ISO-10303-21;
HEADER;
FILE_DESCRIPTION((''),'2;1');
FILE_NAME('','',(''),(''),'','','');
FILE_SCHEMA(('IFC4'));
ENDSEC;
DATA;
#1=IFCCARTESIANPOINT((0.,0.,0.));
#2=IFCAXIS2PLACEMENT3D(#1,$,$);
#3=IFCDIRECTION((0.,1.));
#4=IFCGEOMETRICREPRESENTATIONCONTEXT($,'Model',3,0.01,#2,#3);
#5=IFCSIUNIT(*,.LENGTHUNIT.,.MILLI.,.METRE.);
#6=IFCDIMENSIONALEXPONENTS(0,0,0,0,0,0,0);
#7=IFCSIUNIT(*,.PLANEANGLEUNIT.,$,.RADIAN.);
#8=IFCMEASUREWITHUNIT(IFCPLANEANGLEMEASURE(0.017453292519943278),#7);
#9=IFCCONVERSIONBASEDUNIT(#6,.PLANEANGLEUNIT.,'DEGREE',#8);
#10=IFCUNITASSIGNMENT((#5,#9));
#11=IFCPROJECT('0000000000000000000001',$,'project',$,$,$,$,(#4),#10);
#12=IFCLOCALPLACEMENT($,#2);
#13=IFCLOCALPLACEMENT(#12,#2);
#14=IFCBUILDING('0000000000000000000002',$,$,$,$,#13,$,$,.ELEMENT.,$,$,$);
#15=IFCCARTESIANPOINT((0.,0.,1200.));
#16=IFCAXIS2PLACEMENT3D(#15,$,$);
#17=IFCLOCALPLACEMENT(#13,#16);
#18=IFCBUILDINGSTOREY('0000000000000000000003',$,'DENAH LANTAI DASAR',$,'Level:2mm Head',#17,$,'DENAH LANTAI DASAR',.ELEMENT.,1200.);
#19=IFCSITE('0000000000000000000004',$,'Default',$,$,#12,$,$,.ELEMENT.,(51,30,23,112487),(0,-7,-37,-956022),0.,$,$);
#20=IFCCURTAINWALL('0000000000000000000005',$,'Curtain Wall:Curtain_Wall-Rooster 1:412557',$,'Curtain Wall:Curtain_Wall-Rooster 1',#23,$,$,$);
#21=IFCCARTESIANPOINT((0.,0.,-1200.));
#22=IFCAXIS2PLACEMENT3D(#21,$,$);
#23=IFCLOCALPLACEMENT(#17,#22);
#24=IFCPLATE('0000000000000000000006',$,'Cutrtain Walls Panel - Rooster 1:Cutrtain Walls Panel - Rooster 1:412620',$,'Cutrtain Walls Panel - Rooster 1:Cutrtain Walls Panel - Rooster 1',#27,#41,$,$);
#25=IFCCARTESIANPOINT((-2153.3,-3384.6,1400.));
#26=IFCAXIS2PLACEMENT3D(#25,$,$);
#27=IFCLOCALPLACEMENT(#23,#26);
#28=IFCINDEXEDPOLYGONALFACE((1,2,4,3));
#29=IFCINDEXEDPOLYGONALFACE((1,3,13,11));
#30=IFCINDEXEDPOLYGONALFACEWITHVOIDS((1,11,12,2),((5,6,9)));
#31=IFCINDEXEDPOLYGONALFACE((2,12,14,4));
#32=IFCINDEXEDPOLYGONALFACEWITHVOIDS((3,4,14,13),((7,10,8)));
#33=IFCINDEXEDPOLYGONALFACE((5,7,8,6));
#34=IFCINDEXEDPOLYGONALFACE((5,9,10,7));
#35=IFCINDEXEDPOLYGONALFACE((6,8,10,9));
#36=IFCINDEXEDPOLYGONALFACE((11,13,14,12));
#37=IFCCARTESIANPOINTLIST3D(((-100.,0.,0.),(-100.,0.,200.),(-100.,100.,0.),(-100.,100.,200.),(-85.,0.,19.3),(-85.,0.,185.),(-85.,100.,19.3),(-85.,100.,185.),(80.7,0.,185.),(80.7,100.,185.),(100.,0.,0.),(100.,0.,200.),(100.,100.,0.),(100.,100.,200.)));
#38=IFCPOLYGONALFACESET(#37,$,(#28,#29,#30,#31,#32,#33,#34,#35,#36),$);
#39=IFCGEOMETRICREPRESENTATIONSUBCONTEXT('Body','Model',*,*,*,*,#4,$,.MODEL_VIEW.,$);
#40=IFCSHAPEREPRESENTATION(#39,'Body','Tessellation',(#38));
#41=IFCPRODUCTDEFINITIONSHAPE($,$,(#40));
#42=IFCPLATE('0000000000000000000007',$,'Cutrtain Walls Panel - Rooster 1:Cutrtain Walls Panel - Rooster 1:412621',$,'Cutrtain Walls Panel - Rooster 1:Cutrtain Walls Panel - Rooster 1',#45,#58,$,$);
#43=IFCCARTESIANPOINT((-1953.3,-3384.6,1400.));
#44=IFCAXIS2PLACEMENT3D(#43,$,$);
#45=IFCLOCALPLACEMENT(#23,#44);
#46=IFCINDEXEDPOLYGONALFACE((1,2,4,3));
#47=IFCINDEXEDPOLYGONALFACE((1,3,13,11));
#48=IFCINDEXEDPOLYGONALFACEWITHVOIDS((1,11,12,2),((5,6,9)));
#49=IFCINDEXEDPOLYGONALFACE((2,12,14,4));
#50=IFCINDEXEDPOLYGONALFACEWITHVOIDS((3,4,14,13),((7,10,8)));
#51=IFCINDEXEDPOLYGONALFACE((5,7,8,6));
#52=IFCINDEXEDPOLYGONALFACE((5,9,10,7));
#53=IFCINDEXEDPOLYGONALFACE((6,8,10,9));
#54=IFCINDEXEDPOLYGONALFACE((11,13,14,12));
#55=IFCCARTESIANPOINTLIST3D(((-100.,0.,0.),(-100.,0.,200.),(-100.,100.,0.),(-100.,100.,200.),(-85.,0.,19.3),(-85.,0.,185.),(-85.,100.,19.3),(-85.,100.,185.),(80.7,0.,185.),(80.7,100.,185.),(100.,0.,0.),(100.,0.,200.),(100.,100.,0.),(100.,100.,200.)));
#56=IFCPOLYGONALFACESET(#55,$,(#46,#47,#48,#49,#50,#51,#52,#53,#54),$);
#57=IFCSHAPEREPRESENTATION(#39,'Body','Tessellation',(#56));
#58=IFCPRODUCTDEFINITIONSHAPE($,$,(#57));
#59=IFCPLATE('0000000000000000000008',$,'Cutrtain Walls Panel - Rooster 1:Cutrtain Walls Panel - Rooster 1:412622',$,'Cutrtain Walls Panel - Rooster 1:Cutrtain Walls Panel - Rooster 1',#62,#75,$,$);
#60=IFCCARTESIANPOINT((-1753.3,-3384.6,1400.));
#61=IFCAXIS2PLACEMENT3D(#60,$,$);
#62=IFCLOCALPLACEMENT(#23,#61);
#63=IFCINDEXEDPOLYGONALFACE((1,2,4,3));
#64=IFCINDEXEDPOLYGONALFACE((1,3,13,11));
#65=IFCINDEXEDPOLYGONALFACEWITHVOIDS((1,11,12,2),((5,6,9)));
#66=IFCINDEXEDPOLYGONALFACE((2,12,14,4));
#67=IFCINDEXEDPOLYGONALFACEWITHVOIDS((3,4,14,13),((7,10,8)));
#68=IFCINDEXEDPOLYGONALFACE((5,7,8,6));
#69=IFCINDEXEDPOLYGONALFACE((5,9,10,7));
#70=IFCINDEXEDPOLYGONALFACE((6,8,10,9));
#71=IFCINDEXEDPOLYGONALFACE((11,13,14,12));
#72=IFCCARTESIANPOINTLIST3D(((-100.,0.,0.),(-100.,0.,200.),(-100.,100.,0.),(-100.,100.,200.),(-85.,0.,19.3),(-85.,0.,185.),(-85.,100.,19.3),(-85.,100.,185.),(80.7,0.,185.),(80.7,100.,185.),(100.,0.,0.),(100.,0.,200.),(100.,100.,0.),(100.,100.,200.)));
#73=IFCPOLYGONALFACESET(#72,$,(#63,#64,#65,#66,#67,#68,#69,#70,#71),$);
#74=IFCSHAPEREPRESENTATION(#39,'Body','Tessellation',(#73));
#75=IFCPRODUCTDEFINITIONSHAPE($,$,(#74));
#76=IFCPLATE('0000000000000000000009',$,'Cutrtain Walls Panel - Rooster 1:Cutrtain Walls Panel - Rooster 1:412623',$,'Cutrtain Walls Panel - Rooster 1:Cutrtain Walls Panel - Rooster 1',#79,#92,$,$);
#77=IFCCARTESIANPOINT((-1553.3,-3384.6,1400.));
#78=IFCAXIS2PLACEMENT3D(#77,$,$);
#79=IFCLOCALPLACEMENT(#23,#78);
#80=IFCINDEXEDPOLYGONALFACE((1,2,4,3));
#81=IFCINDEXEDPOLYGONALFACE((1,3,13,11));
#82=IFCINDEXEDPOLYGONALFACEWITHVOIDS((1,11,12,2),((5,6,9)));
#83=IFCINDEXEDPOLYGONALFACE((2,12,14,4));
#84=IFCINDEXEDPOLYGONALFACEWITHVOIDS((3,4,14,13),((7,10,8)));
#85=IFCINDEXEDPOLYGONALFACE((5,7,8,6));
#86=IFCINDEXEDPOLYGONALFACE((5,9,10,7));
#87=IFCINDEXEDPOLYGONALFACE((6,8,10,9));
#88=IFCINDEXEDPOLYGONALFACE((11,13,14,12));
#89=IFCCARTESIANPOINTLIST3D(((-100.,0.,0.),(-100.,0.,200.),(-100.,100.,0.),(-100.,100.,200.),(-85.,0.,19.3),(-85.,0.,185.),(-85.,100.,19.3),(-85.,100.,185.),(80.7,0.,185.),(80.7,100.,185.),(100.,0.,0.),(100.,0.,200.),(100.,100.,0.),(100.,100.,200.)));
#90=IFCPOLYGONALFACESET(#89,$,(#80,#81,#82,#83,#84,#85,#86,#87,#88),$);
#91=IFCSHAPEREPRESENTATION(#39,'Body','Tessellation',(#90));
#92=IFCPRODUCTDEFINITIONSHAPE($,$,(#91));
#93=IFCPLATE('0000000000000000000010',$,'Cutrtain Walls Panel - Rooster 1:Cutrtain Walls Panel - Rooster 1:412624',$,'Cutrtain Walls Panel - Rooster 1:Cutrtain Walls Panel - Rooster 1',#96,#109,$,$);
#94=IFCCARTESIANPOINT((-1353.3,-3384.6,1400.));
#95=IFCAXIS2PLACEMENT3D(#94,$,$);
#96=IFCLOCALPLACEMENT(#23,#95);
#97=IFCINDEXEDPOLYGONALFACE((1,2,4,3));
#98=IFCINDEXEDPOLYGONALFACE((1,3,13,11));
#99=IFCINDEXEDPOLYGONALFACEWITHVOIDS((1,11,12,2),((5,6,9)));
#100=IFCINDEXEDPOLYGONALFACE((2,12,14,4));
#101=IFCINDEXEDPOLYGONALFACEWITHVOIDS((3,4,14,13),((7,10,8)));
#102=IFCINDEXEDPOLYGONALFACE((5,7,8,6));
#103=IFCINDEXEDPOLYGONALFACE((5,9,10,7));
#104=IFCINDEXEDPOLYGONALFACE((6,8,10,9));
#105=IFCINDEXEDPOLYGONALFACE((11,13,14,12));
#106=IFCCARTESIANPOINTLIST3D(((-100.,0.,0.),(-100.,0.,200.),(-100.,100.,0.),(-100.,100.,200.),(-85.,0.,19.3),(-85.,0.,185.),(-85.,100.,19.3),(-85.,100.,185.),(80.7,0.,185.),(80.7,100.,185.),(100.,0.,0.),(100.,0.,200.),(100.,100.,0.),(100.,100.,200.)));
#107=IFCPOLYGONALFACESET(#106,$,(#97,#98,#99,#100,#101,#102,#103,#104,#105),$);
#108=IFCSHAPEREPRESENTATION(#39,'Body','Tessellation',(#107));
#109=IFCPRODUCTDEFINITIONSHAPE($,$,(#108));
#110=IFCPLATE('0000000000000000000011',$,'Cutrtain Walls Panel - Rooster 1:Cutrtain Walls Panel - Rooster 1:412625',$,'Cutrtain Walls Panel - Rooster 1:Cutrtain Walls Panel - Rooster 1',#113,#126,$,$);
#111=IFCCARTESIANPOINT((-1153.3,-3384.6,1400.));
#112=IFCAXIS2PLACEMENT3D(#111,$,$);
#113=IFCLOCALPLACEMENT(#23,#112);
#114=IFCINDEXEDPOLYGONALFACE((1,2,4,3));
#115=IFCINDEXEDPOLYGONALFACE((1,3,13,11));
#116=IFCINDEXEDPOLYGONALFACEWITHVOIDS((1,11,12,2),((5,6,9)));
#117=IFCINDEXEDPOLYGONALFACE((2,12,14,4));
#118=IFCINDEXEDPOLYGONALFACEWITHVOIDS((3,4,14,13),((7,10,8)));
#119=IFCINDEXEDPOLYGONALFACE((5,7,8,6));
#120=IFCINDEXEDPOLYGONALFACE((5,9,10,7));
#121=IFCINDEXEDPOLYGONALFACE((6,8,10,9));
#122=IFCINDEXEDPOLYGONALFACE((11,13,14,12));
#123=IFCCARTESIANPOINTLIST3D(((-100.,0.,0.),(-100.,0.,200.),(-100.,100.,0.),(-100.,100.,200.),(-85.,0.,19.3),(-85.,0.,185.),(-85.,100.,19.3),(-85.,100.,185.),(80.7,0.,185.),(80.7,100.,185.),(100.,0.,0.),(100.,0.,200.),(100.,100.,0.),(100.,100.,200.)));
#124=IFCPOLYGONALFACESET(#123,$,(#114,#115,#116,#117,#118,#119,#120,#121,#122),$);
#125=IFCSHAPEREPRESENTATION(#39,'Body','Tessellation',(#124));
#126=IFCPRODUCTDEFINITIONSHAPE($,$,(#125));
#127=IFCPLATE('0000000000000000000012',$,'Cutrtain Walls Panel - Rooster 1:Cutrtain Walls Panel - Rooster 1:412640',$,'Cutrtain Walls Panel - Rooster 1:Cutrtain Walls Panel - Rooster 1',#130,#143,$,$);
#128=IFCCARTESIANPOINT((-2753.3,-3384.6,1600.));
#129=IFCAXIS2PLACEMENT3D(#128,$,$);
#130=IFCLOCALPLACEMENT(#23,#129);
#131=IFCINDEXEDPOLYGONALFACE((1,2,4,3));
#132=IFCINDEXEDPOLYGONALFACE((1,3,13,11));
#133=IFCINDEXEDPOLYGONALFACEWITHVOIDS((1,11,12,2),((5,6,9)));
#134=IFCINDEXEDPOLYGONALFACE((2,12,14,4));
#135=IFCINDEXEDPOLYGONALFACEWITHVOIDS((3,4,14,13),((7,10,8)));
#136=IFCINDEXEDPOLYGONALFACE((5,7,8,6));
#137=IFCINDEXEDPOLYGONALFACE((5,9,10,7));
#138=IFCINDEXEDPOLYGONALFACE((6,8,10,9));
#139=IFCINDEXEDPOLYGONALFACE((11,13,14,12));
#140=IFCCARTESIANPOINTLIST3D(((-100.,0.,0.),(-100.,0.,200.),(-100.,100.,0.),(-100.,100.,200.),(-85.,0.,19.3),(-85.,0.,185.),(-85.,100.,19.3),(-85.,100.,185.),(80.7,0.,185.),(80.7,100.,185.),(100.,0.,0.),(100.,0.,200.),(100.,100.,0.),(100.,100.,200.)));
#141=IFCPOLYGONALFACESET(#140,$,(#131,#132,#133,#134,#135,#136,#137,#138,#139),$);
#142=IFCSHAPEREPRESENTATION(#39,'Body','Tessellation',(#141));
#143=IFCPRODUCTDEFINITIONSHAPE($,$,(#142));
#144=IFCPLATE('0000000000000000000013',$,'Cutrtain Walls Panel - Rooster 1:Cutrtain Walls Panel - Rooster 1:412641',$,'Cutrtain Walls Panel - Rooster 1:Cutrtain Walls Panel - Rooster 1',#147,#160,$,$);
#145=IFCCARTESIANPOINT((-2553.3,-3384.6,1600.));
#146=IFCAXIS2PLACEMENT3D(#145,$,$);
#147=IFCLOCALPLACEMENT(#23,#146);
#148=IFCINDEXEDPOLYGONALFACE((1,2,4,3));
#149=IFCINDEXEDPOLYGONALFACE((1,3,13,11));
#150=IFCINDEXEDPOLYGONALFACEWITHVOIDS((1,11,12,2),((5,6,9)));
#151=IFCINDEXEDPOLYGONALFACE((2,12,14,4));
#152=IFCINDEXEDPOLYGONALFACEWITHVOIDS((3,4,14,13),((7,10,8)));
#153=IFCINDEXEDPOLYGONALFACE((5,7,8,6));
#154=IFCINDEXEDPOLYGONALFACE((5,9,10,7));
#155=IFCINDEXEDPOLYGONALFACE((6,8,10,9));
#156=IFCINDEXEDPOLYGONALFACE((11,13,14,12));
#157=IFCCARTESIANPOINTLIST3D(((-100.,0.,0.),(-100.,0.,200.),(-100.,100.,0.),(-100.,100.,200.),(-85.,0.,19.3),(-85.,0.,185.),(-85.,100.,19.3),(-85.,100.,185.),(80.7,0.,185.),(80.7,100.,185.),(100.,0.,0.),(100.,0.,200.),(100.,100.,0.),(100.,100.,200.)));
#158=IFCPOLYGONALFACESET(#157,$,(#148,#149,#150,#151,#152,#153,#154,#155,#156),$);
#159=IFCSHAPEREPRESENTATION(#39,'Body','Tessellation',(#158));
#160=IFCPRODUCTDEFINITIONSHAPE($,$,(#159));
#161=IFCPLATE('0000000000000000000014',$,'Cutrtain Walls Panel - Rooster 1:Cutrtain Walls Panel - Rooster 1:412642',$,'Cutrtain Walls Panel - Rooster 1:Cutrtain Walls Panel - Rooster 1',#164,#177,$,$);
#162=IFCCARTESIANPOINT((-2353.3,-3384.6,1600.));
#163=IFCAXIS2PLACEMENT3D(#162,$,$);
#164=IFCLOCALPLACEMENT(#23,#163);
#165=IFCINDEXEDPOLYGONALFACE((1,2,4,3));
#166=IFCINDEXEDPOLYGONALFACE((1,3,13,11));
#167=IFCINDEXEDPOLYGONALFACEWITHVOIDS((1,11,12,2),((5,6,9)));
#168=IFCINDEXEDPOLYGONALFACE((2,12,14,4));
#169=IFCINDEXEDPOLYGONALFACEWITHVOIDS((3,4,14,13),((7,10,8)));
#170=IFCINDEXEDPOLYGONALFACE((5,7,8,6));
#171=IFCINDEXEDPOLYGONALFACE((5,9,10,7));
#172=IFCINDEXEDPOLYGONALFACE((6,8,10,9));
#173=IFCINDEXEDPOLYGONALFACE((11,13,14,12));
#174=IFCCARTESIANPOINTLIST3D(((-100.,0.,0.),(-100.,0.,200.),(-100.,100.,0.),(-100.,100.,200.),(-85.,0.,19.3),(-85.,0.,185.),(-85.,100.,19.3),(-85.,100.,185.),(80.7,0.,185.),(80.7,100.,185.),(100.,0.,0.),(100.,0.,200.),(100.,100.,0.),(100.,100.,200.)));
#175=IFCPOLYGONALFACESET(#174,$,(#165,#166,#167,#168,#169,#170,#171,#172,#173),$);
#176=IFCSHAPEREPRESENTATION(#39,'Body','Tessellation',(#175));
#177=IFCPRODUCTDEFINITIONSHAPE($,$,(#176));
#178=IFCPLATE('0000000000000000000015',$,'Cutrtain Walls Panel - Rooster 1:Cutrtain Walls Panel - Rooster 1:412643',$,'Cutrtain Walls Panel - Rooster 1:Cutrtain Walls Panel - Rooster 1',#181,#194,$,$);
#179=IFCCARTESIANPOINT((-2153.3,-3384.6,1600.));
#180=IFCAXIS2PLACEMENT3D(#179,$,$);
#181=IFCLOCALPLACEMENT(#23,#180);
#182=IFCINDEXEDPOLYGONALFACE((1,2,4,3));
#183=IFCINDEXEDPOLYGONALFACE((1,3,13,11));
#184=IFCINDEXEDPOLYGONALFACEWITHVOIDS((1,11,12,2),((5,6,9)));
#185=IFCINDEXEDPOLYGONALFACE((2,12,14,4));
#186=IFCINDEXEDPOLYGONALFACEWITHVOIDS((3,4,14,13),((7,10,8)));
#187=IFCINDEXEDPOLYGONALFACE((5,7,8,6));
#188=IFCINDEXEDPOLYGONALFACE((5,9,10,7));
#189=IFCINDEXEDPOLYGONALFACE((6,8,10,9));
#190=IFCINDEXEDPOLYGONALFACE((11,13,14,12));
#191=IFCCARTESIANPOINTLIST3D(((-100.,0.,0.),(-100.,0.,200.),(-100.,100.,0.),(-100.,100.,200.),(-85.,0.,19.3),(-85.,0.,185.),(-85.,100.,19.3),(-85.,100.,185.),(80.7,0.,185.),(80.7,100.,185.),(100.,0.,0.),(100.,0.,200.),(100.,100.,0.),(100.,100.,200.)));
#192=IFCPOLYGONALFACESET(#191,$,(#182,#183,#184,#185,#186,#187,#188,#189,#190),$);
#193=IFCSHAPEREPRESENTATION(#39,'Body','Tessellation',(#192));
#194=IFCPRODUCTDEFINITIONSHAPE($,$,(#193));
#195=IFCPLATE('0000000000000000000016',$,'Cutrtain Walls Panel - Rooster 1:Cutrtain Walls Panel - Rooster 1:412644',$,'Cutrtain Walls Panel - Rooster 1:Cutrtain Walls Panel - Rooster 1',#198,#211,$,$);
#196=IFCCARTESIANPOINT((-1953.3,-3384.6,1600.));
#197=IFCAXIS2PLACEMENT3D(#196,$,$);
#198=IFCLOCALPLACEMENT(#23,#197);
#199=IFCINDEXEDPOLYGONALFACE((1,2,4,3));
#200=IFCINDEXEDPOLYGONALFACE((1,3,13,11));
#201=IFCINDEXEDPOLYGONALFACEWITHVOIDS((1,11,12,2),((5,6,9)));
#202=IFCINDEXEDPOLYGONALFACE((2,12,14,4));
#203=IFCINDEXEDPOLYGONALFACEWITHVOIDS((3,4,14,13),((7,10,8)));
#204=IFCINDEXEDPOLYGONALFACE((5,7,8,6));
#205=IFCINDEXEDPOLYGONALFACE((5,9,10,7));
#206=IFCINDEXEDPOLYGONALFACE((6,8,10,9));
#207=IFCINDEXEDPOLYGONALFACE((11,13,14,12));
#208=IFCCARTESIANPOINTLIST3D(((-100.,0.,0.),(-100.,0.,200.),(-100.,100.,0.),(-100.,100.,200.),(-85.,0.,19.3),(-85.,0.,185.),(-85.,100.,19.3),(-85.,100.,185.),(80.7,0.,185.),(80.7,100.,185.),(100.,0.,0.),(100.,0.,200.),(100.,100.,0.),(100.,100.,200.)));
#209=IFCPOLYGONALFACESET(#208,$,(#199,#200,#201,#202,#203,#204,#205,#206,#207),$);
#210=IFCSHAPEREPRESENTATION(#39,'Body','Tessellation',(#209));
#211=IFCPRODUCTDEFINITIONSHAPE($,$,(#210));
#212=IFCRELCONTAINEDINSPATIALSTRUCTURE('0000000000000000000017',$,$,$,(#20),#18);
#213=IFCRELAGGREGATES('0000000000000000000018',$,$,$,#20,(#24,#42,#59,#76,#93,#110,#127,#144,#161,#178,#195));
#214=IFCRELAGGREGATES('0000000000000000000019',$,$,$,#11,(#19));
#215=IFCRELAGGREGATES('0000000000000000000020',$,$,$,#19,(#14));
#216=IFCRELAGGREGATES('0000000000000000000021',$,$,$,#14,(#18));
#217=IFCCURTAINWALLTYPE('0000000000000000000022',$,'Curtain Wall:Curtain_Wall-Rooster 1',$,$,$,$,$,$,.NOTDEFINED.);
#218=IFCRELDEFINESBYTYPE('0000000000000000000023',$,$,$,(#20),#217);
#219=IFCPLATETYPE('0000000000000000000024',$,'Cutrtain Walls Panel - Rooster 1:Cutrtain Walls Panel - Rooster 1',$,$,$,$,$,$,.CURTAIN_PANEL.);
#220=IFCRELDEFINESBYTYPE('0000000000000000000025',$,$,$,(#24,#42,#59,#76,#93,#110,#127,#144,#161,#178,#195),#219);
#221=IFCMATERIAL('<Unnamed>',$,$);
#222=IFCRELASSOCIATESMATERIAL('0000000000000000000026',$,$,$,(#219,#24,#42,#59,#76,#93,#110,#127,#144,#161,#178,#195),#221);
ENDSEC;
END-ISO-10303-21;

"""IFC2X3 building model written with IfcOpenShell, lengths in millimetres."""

from ifc_helpers import new_model, entity, si_unit, converted_unit, direction, frame, origin, place, context, subcontext, project, spatial, polyline, outline, extrude, source, transform, mapped, material, type_object, type_shapes, element, aggregate, save


model = new_model("IFC2X3")

# Units and contexts
model_context = context("Model", 3, precision=0.01, world=origin(), true_north=direction((0.0, 1.0)))
body_context = subcontext(model_context, "Body", "Model", "MODEL_VIEW")
ifc_project = project(units=[si_unit("LENGTHUNIT", "METRE", prefix="MILLI"), converted_unit("PLANEANGLEUNIT", "DEGREE", entity("IfcPlaneAngleMeasure", 0.017453292519943278), si_unit("PLANEANGLEUNIT", "RADIAN"), dimensions=[0, 0, 0, 0, 0, 0, 0])], contexts=[model_context])

# Site, building, storey
site_placement = place(None, origin())
site = spatial("IfcSite", under=ifc_project, at=site_placement, Name="Default", CompositionType="ELEMENT", RefLatitude=(51, 30, 23, 112487), RefLongitude=(0, -7, -37, -956022), RefElevation=0.0)
building_placement = place(site_placement, origin())
building = spatial("IfcBuilding", under=site, at=building_placement, CompositionType="ELEMENT")
storey_placement = place(building_placement, frame((0.0, 0.0, 1200.0)))
storey = spatial("IfcBuildingStorey", under=building, at=storey_placement, Name="DENAH LANTAI DASAR", ObjectType="Level:2mm Head", LongName="DENAH LANTAI DASAR", CompositionType="ELEMENT", Elevation=1200.0)

# Curtain wall, plates
curtain_wall_type = type_object("IfcCurtainWallType", Name="Curtain Wall:Curtain_Wall-Rooster 1", PredefinedType="NOTDEFINED")
curtain_wall_1_placement = place(storey_placement, frame((0.0, 0.0, -1200.0)))
curtain_wall_1 = element("IfcCurtainWall", 1, at=curtain_wall_1_placement, inside=storey, type_object=curtain_wall_type, Name="Curtain Wall:Curtain_Wall-Rooster 1:412557", ObjectType="Curtain Wall:Curtain_Wall-Rooster 1")
ifc_material = material(Name="<Unnamed>")
plate_type_1 = type_object("IfcPlateType", Name="Cutrtain Walls Panel - Rooster 1:Cutrtain Walls Panel - Rooster 1", PredefinedType="CURTAIN_PANEL", material=ifc_material)
shared_shape_1 = source(origin(), body_context, "Body", "SweptSolid", [
    extrude(outline(polyline([(-100.0, -100.0), (100.0, -100.0), (100.0, 100.0), (-100.0, 100.0), (-100.0, -100.0)]), holes=[polyline([(80.7, 85.0), (-85.0, -80.7), (-85.0, 85.0), (80.7, 85.0)])]), frame((0.0, 0.0, 100.0), z_axis=(0.0, 1.0, 0.0), x_axis=(0.0, 0.0, -1.0)), (0.0, 0.0, 1.0), 100.0),
])
type_shapes(plate_type_1, [shared_shape_1])
plate_1_placement = place(curtain_wall_1_placement, frame((-2153.3, -3384.6, 1400.0)))
plate_1 = element("IfcPlate", 2, at=plate_1_placement, type_object=plate_type_1, material=ifc_material, Name="Cutrtain Walls Panel - Rooster 1:Cutrtain Walls Panel - Rooster 1:412620", ObjectType="Cutrtain Walls Panel - Rooster 1:Cutrtain Walls Panel - Rooster 1", context=body_context, shape_type="MappedRepresentation", body=[
    mapped(shared_shape_1, transform((0.0, 0.0, 0.0), scale=1.0)),
])
plate_2_placement = place(curtain_wall_1_placement, frame((-1953.3, -3384.6, 1400.0)))
plate_2 = element("IfcPlate", 3, at=plate_2_placement, type_object=plate_type_1, material=ifc_material, Name="Cutrtain Walls Panel - Rooster 1:Cutrtain Walls Panel - Rooster 1:412621", ObjectType="Cutrtain Walls Panel - Rooster 1:Cutrtain Walls Panel - Rooster 1", context=body_context, shape_type="MappedRepresentation", body=[
    mapped(shared_shape_1, transform((0.0, 0.0, 0.0), scale=1.0)),
])
plate_3_placement = place(curtain_wall_1_placement, frame((-1753.3, -3384.6, 1400.0)))
plate_3 = element("IfcPlate", 4, at=plate_3_placement, type_object=plate_type_1, material=ifc_material, Name="Cutrtain Walls Panel - Rooster 1:Cutrtain Walls Panel - Rooster 1:412622", ObjectType="Cutrtain Walls Panel - Rooster 1:Cutrtain Walls Panel - Rooster 1", context=body_context, shape_type="MappedRepresentation", body=[
    mapped(shared_shape_1, transform((0.0, 0.0, 0.0), scale=1.0)),
])
plate_4_placement = place(curtain_wall_1_placement, frame((-1553.3, -3384.6, 1400.0)))
plate_4 = element("IfcPlate", 5, at=plate_4_placement, type_object=plate_type_1, material=ifc_material, Name="Cutrtain Walls Panel - Rooster 1:Cutrtain Walls Panel - Rooster 1:412623", ObjectType="Cutrtain Walls Panel - Rooster 1:Cutrtain Walls Panel - Rooster 1", context=body_context, shape_type="MappedRepresentation", body=[
    mapped(shared_shape_1, transform((0.0, 0.0, 0.0), scale=1.0)),
])
plate_5_placement = place(curtain_wall_1_placement, frame((-1353.3, -3384.6, 1400.0)))
plate_5 = element("IfcPlate", 6, at=plate_5_placement, type_object=plate_type_1, material=ifc_material, Name="Cutrtain Walls Panel - Rooster 1:Cutrtain Walls Panel - Rooster 1:412624", ObjectType="Cutrtain Walls Panel - Rooster 1:Cutrtain Walls Panel - Rooster 1", context=body_context, shape_type="MappedRepresentation", body=[
    mapped(shared_shape_1, transform((0.0, 0.0, 0.0), scale=1.0)),
])
plate_6_placement = place(curtain_wall_1_placement, frame((-1153.3, -3384.6, 1400.0)))
plate_6 = element("IfcPlate", 7, at=plate_6_placement, type_object=plate_type_1, material=ifc_material, Name="Cutrtain Walls Panel - Rooster 1:Cutrtain Walls Panel - Rooster 1:412625", ObjectType="Cutrtain Walls Panel - Rooster 1:Cutrtain Walls Panel - Rooster 1", context=body_context, shape_type="MappedRepresentation", body=[
    mapped(shared_shape_1, transform((0.0, 0.0, 0.0), scale=1.0)),
])
plate_7_placement = place(curtain_wall_1_placement, frame((-2753.3, -3384.6, 1600.0)))
plate_7 = element("IfcPlate", 8, at=plate_7_placement, type_object=plate_type_1, material=ifc_material, Name="Cutrtain Walls Panel - Rooster 1:Cutrtain Walls Panel - Rooster 1:412640", ObjectType="Cutrtain Walls Panel - Rooster 1:Cutrtain Walls Panel - Rooster 1", context=body_context, shape_type="MappedRepresentation", body=[
    mapped(shared_shape_1, transform((0.0, 0.0, 0.0), scale=1.0)),
])
plate_8_placement = place(curtain_wall_1_placement, frame((-2553.3, -3384.6, 1600.0)))
plate_8 = element("IfcPlate", 9, at=plate_8_placement, type_object=plate_type_1, material=ifc_material, Name="Cutrtain Walls Panel - Rooster 1:Cutrtain Walls Panel - Rooster 1:412641", ObjectType="Cutrtain Walls Panel - Rooster 1:Cutrtain Walls Panel - Rooster 1", context=body_context, shape_type="MappedRepresentation", body=[
    mapped(shared_shape_1, transform((0.0, 0.0, 0.0), scale=1.0)),
])
plate_9_placement = place(curtain_wall_1_placement, frame((-2353.3, -3384.6, 1600.0)))
plate_9 = element("IfcPlate", 10, at=plate_9_placement, type_object=plate_type_1, material=ifc_material, Name="Cutrtain Walls Panel - Rooster 1:Cutrtain Walls Panel - Rooster 1:412642", ObjectType="Cutrtain Walls Panel - Rooster 1:Cutrtain Walls Panel - Rooster 1", context=body_context, shape_type="MappedRepresentation", body=[
    mapped(shared_shape_1, transform((0.0, 0.0, 0.0), scale=1.0)),
])
plate_10_placement = place(curtain_wall_1_placement, frame((-2153.3, -3384.6, 1600.0)))
plate_10 = element("IfcPlate", 11, at=plate_10_placement, type_object=plate_type_1, material=ifc_material, Name="Cutrtain Walls Panel - Rooster 1:Cutrtain Walls Panel - Rooster 1:412643", ObjectType="Cutrtain Walls Panel - Rooster 1:Cutrtain Walls Panel - Rooster 1", context=body_context, shape_type="MappedRepresentation", body=[
    mapped(shared_shape_1, transform((0.0, 0.0, 0.0), scale=1.0)),
])
plate_11_placement = place(curtain_wall_1_placement, frame((-1953.3, -3384.6, 1600.0)))
plate_11 = element("IfcPlate", 12, at=plate_11_placement, type_object=plate_type_1, material=ifc_material, Name="Cutrtain Walls Panel - Rooster 1:Cutrtain Walls Panel - Rooster 1:412644", ObjectType="Cutrtain Walls Panel - Rooster 1:Cutrtain Walls Panel - Rooster 1", context=body_context, shape_type="MappedRepresentation", body=[
    mapped(shared_shape_1, transform((0.0, 0.0, 0.0), scale=1.0)),
])
aggregate(curtain_wall_1, [plate_1, plate_2, plate_3, plate_4, plate_5, plate_6, plate_7, plate_8, plate_9, plate_10, plate_11])

save(model, "model.ifc")
